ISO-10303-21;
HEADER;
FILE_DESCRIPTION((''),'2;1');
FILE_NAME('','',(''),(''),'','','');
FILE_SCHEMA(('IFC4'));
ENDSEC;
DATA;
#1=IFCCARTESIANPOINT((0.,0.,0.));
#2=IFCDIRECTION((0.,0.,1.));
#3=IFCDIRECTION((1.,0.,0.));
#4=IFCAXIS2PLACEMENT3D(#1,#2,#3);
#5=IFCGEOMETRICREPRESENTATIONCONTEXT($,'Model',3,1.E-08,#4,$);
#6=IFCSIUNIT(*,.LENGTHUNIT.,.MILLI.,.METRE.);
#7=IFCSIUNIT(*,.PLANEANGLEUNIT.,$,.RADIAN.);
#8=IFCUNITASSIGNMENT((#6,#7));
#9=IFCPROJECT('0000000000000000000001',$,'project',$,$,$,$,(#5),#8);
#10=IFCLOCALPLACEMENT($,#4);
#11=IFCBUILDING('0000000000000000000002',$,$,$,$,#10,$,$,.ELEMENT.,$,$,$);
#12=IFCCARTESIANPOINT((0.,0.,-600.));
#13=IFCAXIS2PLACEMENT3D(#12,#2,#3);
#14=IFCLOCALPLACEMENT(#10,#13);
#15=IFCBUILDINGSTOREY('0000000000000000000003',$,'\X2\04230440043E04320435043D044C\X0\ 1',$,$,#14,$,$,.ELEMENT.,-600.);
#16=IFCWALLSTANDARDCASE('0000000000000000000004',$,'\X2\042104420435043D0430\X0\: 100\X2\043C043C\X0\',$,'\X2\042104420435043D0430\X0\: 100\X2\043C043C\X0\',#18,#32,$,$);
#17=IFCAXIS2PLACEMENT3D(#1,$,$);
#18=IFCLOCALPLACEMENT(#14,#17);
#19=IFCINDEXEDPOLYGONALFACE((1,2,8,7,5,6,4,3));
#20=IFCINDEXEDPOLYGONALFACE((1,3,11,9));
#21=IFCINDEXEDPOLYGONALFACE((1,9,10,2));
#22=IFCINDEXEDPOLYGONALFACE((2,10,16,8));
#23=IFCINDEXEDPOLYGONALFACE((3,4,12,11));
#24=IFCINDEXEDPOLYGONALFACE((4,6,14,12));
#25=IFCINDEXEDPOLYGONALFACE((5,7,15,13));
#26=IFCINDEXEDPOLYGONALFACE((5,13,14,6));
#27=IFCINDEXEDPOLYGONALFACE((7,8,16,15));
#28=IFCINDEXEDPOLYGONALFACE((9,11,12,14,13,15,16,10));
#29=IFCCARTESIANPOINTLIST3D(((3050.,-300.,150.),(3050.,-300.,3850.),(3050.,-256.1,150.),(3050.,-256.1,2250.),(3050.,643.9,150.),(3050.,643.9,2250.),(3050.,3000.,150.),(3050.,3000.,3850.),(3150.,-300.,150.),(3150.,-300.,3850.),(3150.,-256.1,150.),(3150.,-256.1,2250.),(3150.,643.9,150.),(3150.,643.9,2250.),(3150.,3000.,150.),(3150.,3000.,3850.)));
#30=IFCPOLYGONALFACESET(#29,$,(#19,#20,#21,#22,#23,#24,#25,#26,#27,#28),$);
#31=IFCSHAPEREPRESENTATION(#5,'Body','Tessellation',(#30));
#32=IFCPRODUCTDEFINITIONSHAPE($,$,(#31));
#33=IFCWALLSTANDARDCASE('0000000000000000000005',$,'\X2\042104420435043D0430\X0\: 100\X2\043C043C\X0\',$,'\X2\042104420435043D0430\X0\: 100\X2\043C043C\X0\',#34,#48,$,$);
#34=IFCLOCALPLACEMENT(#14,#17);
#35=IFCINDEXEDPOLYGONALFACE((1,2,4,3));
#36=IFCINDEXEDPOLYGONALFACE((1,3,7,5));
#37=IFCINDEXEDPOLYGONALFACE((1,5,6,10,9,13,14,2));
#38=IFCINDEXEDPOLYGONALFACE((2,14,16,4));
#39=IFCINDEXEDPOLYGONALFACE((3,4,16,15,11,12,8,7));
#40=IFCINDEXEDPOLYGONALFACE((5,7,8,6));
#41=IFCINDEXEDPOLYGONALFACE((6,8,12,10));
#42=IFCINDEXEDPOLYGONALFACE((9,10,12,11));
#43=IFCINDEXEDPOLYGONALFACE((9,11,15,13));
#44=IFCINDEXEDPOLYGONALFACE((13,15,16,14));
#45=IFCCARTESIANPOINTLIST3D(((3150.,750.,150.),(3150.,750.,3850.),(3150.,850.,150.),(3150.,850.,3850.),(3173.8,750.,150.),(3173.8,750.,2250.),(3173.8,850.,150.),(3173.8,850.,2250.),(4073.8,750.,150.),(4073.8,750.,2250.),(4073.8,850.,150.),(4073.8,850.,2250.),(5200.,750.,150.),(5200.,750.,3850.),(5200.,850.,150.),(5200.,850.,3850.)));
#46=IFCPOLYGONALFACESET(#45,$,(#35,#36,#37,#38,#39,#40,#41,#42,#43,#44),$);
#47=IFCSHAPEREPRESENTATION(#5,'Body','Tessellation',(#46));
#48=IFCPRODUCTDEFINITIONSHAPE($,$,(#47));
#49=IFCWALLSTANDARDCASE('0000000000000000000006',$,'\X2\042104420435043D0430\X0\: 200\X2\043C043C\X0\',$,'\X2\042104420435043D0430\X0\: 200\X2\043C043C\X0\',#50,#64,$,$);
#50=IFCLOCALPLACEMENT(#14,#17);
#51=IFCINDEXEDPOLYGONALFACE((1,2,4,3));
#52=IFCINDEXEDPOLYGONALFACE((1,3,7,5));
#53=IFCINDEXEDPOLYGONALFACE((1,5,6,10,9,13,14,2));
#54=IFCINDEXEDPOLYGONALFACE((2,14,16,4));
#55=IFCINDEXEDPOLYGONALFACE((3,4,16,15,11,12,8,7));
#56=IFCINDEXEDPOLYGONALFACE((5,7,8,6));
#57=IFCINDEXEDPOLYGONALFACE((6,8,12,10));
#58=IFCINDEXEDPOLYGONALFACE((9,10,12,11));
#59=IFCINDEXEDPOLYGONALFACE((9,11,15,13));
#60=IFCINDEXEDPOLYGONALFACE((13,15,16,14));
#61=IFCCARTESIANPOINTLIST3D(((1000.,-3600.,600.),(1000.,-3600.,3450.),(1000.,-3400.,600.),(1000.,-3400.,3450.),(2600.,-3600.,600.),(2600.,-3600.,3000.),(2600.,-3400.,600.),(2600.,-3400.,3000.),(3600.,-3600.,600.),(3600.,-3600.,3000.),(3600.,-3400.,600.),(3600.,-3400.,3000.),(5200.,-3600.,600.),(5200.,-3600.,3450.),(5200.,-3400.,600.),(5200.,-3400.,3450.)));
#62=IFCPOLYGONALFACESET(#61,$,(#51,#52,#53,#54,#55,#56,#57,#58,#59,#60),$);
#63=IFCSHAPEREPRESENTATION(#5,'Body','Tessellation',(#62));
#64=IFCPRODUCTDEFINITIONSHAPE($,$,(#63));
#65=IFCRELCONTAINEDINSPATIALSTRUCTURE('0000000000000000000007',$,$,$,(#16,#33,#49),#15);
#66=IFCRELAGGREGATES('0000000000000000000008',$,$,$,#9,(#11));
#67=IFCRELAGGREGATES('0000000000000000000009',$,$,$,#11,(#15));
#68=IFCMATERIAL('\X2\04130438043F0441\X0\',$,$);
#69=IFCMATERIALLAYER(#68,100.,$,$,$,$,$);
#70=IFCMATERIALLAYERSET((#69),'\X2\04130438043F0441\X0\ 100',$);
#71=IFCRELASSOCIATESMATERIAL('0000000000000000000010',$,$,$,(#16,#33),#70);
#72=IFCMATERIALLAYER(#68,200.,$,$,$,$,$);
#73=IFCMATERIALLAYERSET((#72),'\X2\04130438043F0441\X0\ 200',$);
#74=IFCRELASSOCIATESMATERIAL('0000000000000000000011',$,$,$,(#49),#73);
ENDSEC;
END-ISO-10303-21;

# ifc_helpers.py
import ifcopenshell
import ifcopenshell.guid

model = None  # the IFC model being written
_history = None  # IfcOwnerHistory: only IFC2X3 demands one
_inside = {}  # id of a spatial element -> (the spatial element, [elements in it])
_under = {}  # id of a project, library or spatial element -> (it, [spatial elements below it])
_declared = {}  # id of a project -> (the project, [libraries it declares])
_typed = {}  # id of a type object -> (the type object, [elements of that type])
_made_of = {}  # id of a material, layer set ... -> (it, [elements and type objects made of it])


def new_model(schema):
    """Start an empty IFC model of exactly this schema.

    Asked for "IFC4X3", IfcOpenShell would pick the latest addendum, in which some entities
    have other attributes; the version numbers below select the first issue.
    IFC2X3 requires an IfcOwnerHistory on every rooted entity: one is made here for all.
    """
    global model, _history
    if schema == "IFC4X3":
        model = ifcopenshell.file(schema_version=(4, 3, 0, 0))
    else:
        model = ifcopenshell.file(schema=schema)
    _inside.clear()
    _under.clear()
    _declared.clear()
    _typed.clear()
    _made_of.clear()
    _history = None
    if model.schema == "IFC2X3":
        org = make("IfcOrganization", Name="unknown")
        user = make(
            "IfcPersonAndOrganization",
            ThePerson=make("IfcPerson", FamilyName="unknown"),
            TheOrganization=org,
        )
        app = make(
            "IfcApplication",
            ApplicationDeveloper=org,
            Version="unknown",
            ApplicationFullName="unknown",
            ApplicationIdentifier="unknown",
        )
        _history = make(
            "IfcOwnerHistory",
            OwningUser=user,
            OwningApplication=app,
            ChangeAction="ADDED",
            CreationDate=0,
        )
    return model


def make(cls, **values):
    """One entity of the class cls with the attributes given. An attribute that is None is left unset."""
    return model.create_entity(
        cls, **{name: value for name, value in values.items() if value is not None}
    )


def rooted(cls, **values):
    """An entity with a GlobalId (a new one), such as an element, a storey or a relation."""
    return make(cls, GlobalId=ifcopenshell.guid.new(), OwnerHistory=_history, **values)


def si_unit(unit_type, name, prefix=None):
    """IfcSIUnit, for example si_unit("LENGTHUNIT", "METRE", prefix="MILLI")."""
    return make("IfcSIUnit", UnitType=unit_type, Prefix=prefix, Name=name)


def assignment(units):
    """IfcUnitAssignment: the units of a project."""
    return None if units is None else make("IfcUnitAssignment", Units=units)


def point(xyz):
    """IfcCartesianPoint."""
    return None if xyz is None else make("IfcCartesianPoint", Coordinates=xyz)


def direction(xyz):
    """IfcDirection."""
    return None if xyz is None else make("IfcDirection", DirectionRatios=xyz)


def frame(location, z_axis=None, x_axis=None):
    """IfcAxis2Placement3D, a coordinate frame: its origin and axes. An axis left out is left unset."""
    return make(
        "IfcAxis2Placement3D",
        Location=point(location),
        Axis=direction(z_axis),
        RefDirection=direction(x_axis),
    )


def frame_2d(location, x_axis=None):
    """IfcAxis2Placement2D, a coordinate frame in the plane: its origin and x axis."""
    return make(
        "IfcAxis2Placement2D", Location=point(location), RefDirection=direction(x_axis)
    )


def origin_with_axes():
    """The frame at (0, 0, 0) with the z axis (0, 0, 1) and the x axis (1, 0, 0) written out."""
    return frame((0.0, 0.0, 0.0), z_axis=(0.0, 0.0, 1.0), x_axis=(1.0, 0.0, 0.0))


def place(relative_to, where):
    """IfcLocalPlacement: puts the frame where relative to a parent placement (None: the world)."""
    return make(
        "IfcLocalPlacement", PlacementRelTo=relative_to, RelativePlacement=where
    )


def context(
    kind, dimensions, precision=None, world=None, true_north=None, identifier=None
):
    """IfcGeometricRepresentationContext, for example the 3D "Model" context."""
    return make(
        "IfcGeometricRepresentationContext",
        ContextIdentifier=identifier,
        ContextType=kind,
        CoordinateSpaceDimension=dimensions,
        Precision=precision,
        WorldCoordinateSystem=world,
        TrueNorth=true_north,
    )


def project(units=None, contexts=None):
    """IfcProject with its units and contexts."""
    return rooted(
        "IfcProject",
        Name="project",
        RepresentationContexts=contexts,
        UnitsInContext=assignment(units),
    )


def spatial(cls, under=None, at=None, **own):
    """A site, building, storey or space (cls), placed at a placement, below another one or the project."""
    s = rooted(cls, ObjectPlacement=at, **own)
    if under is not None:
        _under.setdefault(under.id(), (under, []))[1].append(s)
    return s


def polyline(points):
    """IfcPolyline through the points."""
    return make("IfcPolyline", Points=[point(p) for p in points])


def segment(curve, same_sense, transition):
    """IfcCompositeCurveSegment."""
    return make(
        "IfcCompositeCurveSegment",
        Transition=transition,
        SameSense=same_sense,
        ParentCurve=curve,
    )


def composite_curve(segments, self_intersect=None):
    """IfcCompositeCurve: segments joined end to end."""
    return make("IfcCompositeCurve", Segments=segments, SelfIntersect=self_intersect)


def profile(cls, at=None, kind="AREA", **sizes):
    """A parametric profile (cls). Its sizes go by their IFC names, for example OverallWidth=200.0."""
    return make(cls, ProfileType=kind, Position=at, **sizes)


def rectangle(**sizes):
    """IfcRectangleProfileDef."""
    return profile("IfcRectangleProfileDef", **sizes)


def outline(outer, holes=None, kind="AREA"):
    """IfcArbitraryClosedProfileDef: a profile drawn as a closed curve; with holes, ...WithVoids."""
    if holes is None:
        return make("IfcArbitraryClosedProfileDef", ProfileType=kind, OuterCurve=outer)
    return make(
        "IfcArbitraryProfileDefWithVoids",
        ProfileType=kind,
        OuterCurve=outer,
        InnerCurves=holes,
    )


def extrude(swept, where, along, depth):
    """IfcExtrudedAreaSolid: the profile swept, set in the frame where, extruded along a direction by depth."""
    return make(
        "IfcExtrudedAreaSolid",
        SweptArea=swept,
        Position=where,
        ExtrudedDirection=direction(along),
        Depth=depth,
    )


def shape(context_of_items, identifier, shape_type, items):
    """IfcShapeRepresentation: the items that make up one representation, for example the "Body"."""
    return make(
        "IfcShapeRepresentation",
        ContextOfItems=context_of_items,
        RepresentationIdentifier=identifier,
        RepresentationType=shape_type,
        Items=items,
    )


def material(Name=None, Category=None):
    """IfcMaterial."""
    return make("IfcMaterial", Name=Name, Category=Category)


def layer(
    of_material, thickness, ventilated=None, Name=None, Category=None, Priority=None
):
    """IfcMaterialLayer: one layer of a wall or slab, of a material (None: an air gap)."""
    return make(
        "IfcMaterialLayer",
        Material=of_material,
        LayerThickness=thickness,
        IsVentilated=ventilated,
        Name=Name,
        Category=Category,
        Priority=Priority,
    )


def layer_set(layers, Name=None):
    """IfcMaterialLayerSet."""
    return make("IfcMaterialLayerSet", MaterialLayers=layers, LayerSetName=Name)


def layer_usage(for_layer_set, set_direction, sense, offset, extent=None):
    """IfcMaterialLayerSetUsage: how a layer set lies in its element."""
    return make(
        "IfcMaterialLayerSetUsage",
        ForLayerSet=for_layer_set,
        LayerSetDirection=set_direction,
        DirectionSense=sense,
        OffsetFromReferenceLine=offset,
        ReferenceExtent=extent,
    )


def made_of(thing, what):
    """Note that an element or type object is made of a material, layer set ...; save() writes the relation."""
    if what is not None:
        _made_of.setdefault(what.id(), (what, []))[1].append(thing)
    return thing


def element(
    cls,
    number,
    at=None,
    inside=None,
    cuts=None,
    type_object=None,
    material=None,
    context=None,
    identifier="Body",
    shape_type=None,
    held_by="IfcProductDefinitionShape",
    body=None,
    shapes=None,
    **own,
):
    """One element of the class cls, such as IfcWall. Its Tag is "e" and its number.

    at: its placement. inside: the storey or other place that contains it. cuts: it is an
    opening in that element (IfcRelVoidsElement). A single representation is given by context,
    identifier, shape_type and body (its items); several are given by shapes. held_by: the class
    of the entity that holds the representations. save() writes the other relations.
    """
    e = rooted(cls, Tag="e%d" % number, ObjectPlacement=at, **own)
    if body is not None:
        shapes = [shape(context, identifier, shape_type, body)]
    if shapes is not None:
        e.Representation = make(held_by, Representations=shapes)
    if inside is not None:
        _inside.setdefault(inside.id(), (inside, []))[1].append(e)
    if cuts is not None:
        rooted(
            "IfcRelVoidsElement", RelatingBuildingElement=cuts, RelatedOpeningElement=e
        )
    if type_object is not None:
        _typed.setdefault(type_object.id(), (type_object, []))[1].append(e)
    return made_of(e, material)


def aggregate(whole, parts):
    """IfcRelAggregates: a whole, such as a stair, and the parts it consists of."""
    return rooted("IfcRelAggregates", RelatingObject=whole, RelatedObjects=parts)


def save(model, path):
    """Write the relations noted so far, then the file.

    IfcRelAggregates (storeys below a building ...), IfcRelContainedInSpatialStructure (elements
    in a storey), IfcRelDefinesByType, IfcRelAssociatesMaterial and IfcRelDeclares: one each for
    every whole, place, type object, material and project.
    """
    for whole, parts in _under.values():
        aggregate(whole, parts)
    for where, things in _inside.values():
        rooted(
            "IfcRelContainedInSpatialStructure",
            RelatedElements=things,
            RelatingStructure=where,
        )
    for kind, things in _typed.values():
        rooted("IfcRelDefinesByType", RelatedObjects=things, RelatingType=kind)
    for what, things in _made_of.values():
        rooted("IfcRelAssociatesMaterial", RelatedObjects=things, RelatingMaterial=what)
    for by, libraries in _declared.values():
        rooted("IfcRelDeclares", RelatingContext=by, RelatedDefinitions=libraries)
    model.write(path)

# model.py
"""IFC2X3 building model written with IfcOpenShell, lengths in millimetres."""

from ifc_helpers import new_model, si_unit, frame, frame_2d, origin_with_axes, place, context, project, spatial, polyline, segment, composite_curve, rectangle, outline, extrude, material, layer, layer_set, layer_usage, element, save


model = new_model("IFC2X3")

# Units and contexts
model_context = context("Model", 3, precision=1e-08, world=origin_with_axes())
ifc_project = project(units=[si_unit("LENGTHUNIT", "METRE", prefix="MILLI"), si_unit("PLANEANGLEUNIT", "RADIAN")], contexts=[model_context])

# Building, storey
building_placement = place(None, origin_with_axes())
building = spatial("IfcBuilding", under=ifc_project, at=building_placement, CompositionType="ELEMENT")
storey_placement = place(building_placement, frame((0.0, 0.0, -600.0), z_axis=(0.0, 0.0, 1.0), x_axis=(1.0, 0.0, 0.0)))
storey = spatial("IfcBuildingStorey", under=building, at=storey_placement, Name="Уровень 1", CompositionType="ELEMENT", Elevation=-600.0)

# Walls, openings
ifc_material_1 = material(Name="Гипс")
ifc_layer_1 = layer(ifc_material_1, 200.0)
ifc_layer_set_1 = layer_set([ifc_layer_1], Name="Гипс 200")
ifc_layer_2 = layer(ifc_material_1, 100.0)
ifc_layer_set_2 = layer_set([ifc_layer_2], Name="Гипс 100")
ifc_layer_usage_1 = layer_usage(ifc_layer_set_2, "AXIS2", "NEGATIVE", 50.0)
wall_1_placement = place(storey_placement, frame((3100.0, 3000.0, 150.0), z_axis=(0.0, 0.0, 1.0), x_axis=(0.0, -1.0, 0.0)))
wall_1 = element("IfcWallStandardCase", 1, at=wall_1_placement, inside=storey, material=ifc_layer_usage_1, Name="Стена: 100мм", ObjectType="Стена: 100мм", context=model_context, shape_type="SweptSolid", body=[
    extrude(outline(composite_curve([segment(polyline([(0.0, -50.0), (3300.0, -50.0)]), True, "CONTINUOUS"), segment(polyline([(3300.0, -50.0), (3300.0, 50.0)]), True, "CONTINUOUS"), segment(polyline([(3300.0, 50.0), (0.0, 50.0)]), True, "CONTINUOUS"), segment(polyline([(0.0, 50.0), (0.0, -50.0)]), True, "CONTINUOUS")], self_intersect=False)), origin_with_axes(), (0.0, 0.0, 1.0), 3700.0),
])
opening_1_placement = place(wall_1_placement, frame((2356.1, -50.0, 0.0), z_axis=(0.0, 0.0, 1.0), x_axis=(1.0, 0.0, 0.0)))
element("IfcOpeningElement", 2, at=opening_1_placement, cuts=wall_1, ObjectType="Opening", context=model_context, shape_type="SweptSolid", body=[
    extrude(rectangle(XDim=900.0, YDim=2100.0, at=frame_2d((450.0, 1050.0), x_axis=(1.0, 0.0))), frame((0.0, -5.0, 0.0), z_axis=(0.0, -1.0, 0.0), x_axis=(1.0, 0.0, 0.0)), (0.0, 0.0, -1.0), 110.0),
])
ifc_layer_usage_2 = layer_usage(ifc_layer_set_2, "AXIS2", "NEGATIVE", 50.0)
wall_2_placement = place(storey_placement, frame((3100.0, 800.0, 150.0), z_axis=(0.0, 0.0, 1.0), x_axis=(1.0, 0.0, 0.0)))
wall_2 = element("IfcWallStandardCase", 3, at=wall_2_placement, inside=storey, material=ifc_layer_usage_2, Name="Стена: 100мм", ObjectType="Стена: 100мм", context=model_context, shape_type="SweptSolid", body=[
    extrude(outline(composite_curve([segment(polyline([(50.0, -50.0), (2100.0, -50.0)]), True, "CONTINUOUS"), segment(polyline([(2100.0, -50.0), (2100.0, 50.0)]), True, "CONTINUOUS"), segment(polyline([(2100.0, 50.0), (50.0, 50.0)]), True, "CONTINUOUS"), segment(polyline([(50.0, 50.0), (50.0, -50.0)]), True, "CONTINUOUS")], self_intersect=False)), origin_with_axes(), (0.0, 0.0, 1.0), 3700.0),
])
opening_2_placement = place(wall_2_placement, frame((973.8, 50.0, 0.0), z_axis=(0.0, 0.0, 1.0), x_axis=(-1.0, 0.0, 0.0)))
element("IfcOpeningElement", 4, at=opening_2_placement, cuts=wall_2, ObjectType="Opening", context=model_context, shape_type="SweptSolid", body=[
    extrude(rectangle(XDim=900.0, YDim=2100.0, at=frame_2d((450.0, 1050.0), x_axis=(1.0, 0.0))), frame((0.0, -5.0, 0.0), z_axis=(0.0, -1.0, 0.0), x_axis=(1.0, 0.0, 0.0)), (0.0, 0.0, -1.0), 110.0),
])
ifc_layer_usage_3 = layer_usage(ifc_layer_set_1, "AXIS2", "NEGATIVE", 200.0)
wall_3_placement = place(storey_placement, frame((1000.0, -3600.0, 600.0), z_axis=(0.0, 0.0, 1.0), x_axis=(1.0, 0.0, 0.0)))
wall_3 = element("IfcWallStandardCase", 5, at=wall_3_placement, inside=storey, material=ifc_layer_usage_3, Name="Стена: 200мм", ObjectType="Стена: 200мм", context=model_context, shape_type="SweptSolid", body=[
    extrude(outline(composite_curve([segment(polyline([(0.0, 0.0), (4200.0, 0.0)]), True, "CONTINUOUS"), segment(polyline([(4200.0, 0.0), (4200.0, 200.0)]), True, "CONTINUOUS"), segment(polyline([(4200.0, 200.0), (0.0, 200.0)]), True, "CONTINUOUS"), segment(polyline([(0.0, 200.0), (0.0, 0.0)]), True, "CONTINUOUS")], self_intersect=False)), origin_with_axes(), (0.0, 0.0, 1.0), 2850.0),
])
opening_3_placement = place(wall_3_placement, frame((2600.0, 200.0, 0.0), z_axis=(0.0, 0.0, 1.0), x_axis=(-1.0, 0.0, 0.0)))
element("IfcOpeningElement", 6, at=opening_3_placement, cuts=wall_3, ObjectType="Opening", context=model_context, shape_type="SweptSolid", body=[
    extrude(rectangle(XDim=1000.0, YDim=2400.0, at=frame_2d((500.0, 1200.0), x_axis=(1.0, 0.0))), frame((0.0, -5.0, 0.0), z_axis=(0.0, -1.0, 0.0), x_axis=(1.0, 0.0, 0.0)), (0.0, 0.0, -1.0), 210.0),
])

save(model, "model.ifc")
